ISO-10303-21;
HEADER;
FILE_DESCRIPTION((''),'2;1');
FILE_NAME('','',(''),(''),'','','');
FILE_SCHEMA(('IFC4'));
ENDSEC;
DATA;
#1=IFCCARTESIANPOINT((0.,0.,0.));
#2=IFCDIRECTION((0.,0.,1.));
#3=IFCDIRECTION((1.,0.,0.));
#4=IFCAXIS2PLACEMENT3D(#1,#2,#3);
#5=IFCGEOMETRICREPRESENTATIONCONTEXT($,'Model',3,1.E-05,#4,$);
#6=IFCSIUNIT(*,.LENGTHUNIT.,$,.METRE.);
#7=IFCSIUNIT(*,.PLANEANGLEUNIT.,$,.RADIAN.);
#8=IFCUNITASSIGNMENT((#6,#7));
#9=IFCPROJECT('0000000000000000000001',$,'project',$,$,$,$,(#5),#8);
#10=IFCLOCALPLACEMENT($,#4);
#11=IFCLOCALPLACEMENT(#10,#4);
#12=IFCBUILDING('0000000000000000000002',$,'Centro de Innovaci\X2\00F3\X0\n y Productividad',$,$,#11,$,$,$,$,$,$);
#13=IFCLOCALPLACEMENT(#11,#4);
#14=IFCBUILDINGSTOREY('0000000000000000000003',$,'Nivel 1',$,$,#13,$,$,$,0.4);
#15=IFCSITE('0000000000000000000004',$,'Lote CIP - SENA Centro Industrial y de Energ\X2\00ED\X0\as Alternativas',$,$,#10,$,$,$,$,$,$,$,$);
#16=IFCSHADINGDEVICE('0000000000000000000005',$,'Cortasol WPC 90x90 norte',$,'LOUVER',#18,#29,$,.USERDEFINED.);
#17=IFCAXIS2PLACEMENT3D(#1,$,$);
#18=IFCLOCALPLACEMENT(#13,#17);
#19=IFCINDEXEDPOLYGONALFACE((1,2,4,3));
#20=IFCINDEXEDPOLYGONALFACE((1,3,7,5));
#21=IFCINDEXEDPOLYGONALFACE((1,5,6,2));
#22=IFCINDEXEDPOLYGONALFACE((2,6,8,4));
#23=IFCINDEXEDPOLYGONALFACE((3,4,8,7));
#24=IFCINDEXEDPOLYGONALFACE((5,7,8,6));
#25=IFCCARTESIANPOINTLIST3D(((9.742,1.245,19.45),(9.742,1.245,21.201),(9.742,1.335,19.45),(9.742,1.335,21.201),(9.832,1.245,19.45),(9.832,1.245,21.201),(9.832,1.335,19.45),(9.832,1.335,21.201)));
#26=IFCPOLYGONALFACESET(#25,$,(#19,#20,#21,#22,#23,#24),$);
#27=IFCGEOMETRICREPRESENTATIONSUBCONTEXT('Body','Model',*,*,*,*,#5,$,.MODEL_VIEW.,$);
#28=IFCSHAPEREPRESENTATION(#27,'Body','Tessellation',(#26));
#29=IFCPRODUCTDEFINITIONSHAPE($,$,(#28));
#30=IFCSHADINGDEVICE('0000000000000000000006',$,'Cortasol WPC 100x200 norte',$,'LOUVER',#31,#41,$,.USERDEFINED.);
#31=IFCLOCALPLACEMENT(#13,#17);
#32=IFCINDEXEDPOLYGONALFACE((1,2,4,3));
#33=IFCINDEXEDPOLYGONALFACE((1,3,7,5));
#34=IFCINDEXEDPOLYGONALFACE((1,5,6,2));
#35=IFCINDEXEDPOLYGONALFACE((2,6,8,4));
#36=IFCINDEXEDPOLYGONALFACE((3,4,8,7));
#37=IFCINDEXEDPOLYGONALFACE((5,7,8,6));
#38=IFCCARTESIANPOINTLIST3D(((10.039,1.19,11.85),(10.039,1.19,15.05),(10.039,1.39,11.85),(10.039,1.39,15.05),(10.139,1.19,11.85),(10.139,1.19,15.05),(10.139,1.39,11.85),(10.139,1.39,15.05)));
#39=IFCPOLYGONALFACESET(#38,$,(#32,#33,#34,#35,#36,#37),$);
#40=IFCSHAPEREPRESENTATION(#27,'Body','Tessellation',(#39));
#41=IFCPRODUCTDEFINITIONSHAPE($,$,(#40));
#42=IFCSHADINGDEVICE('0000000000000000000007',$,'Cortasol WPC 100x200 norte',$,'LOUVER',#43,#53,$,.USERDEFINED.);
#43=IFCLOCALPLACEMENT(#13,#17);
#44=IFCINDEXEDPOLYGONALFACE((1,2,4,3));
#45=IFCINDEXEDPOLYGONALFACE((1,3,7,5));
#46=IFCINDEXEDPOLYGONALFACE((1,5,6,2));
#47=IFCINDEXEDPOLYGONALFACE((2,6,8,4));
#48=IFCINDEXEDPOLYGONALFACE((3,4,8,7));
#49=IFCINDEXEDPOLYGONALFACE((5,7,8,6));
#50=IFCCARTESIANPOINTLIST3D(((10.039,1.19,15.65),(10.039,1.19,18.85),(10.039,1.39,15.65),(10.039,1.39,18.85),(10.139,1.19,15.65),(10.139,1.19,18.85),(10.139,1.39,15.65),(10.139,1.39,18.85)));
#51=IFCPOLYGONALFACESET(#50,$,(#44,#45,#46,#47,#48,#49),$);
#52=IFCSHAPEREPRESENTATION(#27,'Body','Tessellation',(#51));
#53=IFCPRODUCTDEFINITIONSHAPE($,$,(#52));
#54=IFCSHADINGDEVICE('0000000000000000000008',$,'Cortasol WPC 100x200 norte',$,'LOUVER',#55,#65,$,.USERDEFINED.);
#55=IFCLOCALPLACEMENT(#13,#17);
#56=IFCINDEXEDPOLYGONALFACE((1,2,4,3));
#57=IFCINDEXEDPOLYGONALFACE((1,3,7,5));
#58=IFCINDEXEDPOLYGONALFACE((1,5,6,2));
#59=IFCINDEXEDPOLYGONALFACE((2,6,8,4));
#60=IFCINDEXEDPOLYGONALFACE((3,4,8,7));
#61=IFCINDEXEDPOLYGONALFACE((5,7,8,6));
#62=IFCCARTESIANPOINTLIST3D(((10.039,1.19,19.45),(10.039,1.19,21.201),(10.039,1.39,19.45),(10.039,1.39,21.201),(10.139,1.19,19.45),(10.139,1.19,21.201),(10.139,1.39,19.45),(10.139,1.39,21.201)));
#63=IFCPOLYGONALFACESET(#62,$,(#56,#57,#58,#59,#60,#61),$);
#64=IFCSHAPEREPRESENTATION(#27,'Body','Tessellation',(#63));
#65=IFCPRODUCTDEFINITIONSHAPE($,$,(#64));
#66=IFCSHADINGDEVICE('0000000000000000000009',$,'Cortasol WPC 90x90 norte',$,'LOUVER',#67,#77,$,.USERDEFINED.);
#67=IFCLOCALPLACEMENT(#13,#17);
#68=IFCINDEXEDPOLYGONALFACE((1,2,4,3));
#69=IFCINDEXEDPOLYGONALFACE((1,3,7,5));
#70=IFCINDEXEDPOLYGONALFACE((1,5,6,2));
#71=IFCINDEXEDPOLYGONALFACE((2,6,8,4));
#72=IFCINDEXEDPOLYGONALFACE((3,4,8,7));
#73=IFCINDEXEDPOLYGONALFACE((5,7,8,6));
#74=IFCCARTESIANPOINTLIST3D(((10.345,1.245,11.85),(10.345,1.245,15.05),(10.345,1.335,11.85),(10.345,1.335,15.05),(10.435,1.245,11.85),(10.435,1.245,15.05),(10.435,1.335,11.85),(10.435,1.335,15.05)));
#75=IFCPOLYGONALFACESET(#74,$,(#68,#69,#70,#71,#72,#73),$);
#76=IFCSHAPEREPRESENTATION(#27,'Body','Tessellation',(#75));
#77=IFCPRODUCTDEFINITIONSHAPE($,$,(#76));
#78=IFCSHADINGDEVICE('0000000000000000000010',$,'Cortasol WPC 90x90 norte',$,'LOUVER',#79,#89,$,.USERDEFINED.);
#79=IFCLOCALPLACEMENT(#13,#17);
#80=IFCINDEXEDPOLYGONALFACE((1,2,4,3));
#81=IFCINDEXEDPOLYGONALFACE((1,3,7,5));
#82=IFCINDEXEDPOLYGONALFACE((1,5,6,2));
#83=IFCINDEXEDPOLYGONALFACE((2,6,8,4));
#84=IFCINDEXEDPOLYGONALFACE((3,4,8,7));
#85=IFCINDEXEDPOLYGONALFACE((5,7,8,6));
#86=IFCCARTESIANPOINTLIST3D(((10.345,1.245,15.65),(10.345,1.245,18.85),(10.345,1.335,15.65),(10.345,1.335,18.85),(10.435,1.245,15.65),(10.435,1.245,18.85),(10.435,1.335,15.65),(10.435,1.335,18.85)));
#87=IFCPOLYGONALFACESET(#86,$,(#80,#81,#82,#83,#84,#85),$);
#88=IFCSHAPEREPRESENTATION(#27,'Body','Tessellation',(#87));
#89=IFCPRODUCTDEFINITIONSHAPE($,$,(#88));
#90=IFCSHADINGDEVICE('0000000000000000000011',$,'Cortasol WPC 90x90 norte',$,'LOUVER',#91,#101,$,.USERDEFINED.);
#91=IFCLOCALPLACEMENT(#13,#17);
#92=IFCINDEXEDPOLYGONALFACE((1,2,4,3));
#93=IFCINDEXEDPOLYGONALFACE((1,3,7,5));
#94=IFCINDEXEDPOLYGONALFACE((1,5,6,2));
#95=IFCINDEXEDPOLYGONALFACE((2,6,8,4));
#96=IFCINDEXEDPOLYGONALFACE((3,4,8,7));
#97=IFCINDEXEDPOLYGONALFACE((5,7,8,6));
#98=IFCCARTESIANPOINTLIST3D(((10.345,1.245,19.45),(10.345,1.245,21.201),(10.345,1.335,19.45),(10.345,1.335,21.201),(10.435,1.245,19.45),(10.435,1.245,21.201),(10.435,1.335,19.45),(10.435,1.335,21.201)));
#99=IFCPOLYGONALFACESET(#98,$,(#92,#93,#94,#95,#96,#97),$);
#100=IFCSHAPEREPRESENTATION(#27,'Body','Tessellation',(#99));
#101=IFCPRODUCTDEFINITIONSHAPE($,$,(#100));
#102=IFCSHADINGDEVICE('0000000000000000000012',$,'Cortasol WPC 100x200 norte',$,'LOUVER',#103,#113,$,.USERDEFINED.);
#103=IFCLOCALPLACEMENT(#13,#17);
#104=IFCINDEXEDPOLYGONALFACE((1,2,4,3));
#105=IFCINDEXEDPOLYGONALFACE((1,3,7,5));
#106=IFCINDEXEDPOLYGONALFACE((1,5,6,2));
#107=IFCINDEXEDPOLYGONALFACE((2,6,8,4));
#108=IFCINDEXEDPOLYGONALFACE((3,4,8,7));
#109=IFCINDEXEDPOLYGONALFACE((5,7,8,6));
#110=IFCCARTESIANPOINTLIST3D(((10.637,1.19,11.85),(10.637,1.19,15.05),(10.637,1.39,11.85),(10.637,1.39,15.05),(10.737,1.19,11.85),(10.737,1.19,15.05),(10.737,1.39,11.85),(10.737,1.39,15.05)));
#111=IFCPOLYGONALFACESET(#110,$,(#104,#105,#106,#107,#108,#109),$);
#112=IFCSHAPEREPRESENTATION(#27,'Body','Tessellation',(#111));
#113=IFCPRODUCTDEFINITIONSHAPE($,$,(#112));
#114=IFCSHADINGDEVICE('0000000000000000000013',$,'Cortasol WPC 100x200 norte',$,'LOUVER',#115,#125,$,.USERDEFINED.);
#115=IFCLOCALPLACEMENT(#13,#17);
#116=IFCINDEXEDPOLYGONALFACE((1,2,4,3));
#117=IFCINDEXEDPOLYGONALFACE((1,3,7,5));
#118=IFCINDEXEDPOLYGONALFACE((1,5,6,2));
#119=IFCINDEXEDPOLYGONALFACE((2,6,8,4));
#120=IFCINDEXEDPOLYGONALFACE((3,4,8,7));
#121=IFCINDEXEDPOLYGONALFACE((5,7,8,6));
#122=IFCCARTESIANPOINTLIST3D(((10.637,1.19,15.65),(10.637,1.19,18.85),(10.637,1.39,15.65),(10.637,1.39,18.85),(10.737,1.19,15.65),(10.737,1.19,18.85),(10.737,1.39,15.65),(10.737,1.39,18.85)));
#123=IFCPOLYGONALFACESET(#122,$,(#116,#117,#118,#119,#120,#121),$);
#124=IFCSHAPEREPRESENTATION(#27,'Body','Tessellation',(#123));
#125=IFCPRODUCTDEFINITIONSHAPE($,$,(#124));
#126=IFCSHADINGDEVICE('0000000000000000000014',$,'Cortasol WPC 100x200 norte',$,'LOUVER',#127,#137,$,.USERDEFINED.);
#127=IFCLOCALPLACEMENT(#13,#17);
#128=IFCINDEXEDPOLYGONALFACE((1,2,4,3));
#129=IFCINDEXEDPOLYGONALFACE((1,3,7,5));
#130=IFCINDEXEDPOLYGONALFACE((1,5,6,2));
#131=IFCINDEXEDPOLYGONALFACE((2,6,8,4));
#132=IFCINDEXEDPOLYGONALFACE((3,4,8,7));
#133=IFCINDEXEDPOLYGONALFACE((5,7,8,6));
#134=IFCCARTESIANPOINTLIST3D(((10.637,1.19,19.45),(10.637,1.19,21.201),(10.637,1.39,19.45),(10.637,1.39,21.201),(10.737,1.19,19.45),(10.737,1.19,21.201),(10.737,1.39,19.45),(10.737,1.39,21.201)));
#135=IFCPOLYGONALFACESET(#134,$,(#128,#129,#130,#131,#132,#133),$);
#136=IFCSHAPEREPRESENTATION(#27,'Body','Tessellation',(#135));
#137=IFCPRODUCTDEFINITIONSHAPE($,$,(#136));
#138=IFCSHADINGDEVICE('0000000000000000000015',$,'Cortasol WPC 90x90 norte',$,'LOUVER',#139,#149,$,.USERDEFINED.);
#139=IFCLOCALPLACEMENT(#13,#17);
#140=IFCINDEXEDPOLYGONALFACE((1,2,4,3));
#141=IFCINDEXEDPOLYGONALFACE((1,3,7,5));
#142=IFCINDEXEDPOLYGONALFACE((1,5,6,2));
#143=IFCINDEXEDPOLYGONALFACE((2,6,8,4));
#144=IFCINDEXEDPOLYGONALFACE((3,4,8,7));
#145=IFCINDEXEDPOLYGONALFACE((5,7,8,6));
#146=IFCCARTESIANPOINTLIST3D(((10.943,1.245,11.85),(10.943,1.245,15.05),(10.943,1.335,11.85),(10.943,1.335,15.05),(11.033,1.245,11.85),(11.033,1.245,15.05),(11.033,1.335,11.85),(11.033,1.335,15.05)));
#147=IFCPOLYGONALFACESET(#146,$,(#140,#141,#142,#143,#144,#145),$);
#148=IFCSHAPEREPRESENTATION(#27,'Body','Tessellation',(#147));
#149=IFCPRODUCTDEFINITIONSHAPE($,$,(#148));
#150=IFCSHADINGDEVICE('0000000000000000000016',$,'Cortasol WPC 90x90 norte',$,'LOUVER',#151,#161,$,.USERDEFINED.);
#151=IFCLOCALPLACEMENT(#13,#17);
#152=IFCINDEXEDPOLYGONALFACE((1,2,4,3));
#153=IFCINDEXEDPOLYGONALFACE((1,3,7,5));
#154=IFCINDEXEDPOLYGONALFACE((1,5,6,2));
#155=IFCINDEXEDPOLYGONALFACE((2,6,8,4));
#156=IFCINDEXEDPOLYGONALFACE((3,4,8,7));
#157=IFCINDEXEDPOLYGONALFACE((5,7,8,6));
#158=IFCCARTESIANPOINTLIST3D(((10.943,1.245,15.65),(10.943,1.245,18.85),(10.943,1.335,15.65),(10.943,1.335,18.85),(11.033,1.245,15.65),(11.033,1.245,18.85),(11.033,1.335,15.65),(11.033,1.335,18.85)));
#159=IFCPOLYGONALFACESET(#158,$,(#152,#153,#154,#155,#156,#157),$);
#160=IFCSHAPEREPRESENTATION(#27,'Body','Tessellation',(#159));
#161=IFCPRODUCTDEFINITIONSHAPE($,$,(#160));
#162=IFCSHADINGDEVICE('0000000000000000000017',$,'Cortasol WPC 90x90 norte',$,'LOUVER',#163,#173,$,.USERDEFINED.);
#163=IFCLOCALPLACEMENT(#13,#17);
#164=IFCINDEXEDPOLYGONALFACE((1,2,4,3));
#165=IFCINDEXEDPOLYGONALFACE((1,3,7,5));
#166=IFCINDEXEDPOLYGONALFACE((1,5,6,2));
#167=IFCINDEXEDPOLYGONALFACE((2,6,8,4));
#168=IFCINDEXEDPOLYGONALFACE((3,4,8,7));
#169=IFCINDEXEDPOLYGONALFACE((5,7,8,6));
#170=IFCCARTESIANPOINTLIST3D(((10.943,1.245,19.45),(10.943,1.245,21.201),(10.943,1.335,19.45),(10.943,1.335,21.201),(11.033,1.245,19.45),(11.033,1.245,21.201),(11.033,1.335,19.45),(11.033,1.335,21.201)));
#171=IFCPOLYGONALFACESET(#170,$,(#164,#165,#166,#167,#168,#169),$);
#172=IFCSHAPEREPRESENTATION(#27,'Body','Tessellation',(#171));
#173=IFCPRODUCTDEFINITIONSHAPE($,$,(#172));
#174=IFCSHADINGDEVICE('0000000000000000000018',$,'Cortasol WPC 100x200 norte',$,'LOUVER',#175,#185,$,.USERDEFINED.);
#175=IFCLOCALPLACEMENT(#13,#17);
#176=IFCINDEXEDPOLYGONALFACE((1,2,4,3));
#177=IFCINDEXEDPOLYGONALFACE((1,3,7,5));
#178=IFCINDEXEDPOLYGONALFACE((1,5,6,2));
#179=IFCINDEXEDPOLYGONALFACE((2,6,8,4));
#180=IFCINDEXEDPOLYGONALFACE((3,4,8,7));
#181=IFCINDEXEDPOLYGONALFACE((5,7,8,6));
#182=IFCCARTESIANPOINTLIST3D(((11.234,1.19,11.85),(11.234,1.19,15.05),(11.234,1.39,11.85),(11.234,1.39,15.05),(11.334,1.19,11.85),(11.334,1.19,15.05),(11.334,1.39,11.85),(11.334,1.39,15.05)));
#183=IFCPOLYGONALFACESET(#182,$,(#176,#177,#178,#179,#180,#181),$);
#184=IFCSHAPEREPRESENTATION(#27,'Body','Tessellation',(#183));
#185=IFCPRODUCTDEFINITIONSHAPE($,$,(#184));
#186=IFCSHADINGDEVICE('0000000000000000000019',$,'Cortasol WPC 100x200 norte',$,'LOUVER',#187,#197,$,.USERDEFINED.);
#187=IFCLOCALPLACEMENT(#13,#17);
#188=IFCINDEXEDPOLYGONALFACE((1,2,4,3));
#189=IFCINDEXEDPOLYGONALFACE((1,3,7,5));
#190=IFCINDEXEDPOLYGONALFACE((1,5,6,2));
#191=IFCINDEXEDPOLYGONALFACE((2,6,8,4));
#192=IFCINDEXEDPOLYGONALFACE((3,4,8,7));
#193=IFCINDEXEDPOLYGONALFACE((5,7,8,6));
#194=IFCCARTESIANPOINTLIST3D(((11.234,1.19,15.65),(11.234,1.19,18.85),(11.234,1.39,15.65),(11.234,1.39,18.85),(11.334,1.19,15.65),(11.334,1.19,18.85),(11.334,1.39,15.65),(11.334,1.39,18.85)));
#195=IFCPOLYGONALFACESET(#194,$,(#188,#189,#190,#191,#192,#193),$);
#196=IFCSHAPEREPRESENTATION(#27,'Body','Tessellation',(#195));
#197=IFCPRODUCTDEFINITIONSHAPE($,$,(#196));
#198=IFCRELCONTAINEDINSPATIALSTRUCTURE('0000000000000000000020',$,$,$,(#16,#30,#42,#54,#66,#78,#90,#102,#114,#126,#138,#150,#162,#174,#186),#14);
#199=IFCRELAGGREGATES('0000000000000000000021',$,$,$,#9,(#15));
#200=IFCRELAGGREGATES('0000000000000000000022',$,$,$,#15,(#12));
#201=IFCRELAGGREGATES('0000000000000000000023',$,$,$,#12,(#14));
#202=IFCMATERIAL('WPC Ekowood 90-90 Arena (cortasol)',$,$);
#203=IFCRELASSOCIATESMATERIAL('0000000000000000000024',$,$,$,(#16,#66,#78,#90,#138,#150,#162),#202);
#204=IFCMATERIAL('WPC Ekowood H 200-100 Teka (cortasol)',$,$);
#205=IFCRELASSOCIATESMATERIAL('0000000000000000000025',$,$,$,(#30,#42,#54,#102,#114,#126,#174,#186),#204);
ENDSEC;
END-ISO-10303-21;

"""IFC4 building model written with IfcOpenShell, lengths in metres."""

from ifc_helpers import new_model, si_unit, frame, origin_with_axes, place, context, subcontext, project, spatial, polyline, outline, extrude, material, element, save


model = new_model("IFC4")

# Units and contexts
model_context = context("Model", 3, precision=1e-05, world=origin_with_axes())
body_context = subcontext(model_context, "Body", "Model", "MODEL_VIEW")
ifc_project = project(units=[si_unit("LENGTHUNIT", "METRE"), si_unit("PLANEANGLEUNIT", "RADIAN")], contexts=[model_context])

# Site, building, storey
site_placement = place(None, origin_with_axes())
site = spatial("IfcSite", under=ifc_project, at=site_placement, Name="Lote CIP - SENA Centro Industrial y de Energías Alternativas")
building_placement = place(site_placement, origin_with_axes())
building = spatial("IfcBuilding", under=site, at=building_placement, Name="Centro de Innovación y Productividad")
storey_placement = place(building_placement, origin_with_axes())
storey = spatial("IfcBuildingStorey", under=building, at=storey_placement, Name="Nivel 1", Elevation=0.4)

# Shading devices
ifc_material_1 = material(Name="WPC Ekowood 90-90 Arena (cortasol)")
shading_device_1_placement = place(storey_placement, origin_with_axes())
element("IfcShadingDevice", 1, at=shading_device_1_placement, inside=storey, material=ifc_material_1, Name="Cortasol WPC 90x90 norte", ObjectType="LOUVER", PredefinedType="USERDEFINED", context=body_context, shape_type="SweptSolid", body=[
    extrude(outline(polyline([(9.742, 1.245), (9.742, 1.335), (9.832, 1.335), (9.832, 1.245), (9.742, 1.245)])), frame((0.0, 0.0, 19.45)), (0.0, 0.0, 1.0), 1.751),
])
ifc_material_2 = material(Name="WPC Ekowood H 200-100 Teka (cortasol)")
shading_device_2_placement = place(storey_placement, origin_with_axes())
element("IfcShadingDevice", 2, at=shading_device_2_placement, inside=storey, material=ifc_material_2, Name="Cortasol WPC 100x200 norte", ObjectType="LOUVER", PredefinedType="USERDEFINED", context=body_context, shape_type="SweptSolid", body=[
    extrude(outline(polyline([(10.039, 1.19), (10.039, 1.39), (10.139, 1.39), (10.139, 1.19), (10.039, 1.19)])), frame((0.0, 0.0, 11.85)), (0.0, 0.0, 1.0), 3.2),
])
shading_device_3_placement = place(storey_placement, origin_with_axes())
element("IfcShadingDevice", 3, at=shading_device_3_placement, inside=storey, material=ifc_material_2, Name="Cortasol WPC 100x200 norte", ObjectType="LOUVER", PredefinedType="USERDEFINED", context=body_context, shape_type="SweptSolid", body=[
    extrude(outline(polyline([(10.039, 1.19), (10.039, 1.39), (10.139, 1.39), (10.139, 1.19), (10.039, 1.19)])), frame((0.0, 0.0, 15.65)), (0.0, 0.0, 1.0), 3.2),
])
shading_device_4_placement = place(storey_placement, origin_with_axes())
element("IfcShadingDevice", 4, at=shading_device_4_placement, inside=storey, material=ifc_material_2, Name="Cortasol WPC 100x200 norte", ObjectType="LOUVER", PredefinedType="USERDEFINED", context=body_context, shape_type="SweptSolid", body=[
    extrude(outline(polyline([(10.039, 1.19), (10.039, 1.39), (10.139, 1.39), (10.139, 1.19), (10.039, 1.19)])), frame((0.0, 0.0, 19.45)), (0.0, 0.0, 1.0), 1.751),
])
shading_device_5_placement = place(storey_placement, origin_with_axes())
element("IfcShadingDevice", 5, at=shading_device_5_placement, inside=storey, material=ifc_material_1, Name="Cortasol WPC 90x90 norte", ObjectType="LOUVER", PredefinedType="USERDEFINED", context=body_context, shape_type="SweptSolid", body=[
    extrude(outline(polyline([(10.345, 1.245), (10.345, 1.335), (10.435, 1.335), (10.435, 1.245), (10.345, 1.245)])), frame((0.0, 0.0, 11.85)), (0.0, 0.0, 1.0), 3.2),
])
shading_device_6_placement = place(storey_placement, origin_with_axes())
element("IfcShadingDevice", 6, at=shading_device_6_placement, inside=storey, material=ifc_material_1, Name="Cortasol WPC 90x90 norte", ObjectType="LOUVER", PredefinedType="USERDEFINED", context=body_context, shape_type="SweptSolid", body=[
    extrude(outline(polyline([(10.345, 1.245), (10.345, 1.335), (10.435, 1.335), (10.435, 1.245), (10.345, 1.245)])), frame((0.0, 0.0, 15.65)), (0.0, 0.0, 1.0), 3.2),
])
shading_device_7_placement = place(storey_placement, origin_with_axes())
element("IfcShadingDevice", 7, at=shading_device_7_placement, inside=storey, material=ifc_material_1, Name="Cortasol WPC 90x90 norte", ObjectType="LOUVER", PredefinedType="USERDEFINED", context=body_context, shape_type="SweptSolid", body=[
    extrude(outline(polyline([(10.345, 1.245), (10.345, 1.335), (10.435, 1.335), (10.435, 1.245), (10.345, 1.245)])), frame((0.0, 0.0, 19.45)), (0.0, 0.0, 1.0), 1.751),
])
shading_device_8_placement = place(storey_placement, origin_with_axes())
element("IfcShadingDevice", 8, at=shading_device_8_placement, inside=storey, material=ifc_material_2, Name="Cortasol WPC 100x200 norte", ObjectType="LOUVER", PredefinedType="USERDEFINED", context=body_context, shape_type="SweptSolid", body=[
    extrude(outline(polyline([(10.637, 1.19), (10.637, 1.39), (10.737, 1.39), (10.737, 1.19), (10.637, 1.19)])), frame((0.0, 0.0, 11.85)), (0.0, 0.0, 1.0), 3.2),
])
shading_device_9_placement = place(storey_placement, origin_with_axes())
element("IfcShadingDevice", 9, at=shading_device_9_placement, inside=storey, material=ifc_material_2, Name="Cortasol WPC 100x200 norte", ObjectType="LOUVER", PredefinedType="USERDEFINED", context=body_context, shape_type="SweptSolid", body=[
    extrude(outline(polyline([(10.637, 1.19), (10.637, 1.39), (10.737, 1.39), (10.737, 1.19), (10.637, 1.19)])), frame((0.0, 0.0, 15.65)), (0.0, 0.0, 1.0), 3.2),
])
shading_device_10_placement = place(storey_placement, origin_with_axes())
element("IfcShadingDevice", 10, at=shading_device_10_placement, inside=storey, material=ifc_material_2, Name="Cortasol WPC 100x200 norte", ObjectType="LOUVER", PredefinedType="USERDEFINED", context=body_context, shape_type="SweptSolid", body=[
    extrude(outline(polyline([(10.637, 1.19), (10.637, 1.39), (10.737, 1.39), (10.737, 1.19), (10.637, 1.19)])), frame((0.0, 0.0, 19.45)), (0.0, 0.0, 1.0), 1.751),
])
shading_device_11_placement = place(storey_placement, origin_with_axes())
element("IfcShadingDevice", 11, at=shading_device_11_placement, inside=storey, material=ifc_material_1, Name="Cortasol WPC 90x90 norte", ObjectType="LOUVER", PredefinedType="USERDEFINED", context=body_context, shape_type="SweptSolid", body=[
    extrude(outline(polyline([(10.943, 1.245), (10.943, 1.335), (11.033, 1.335), (11.033, 1.245), (10.943, 1.245)])), frame((0.0, 0.0, 11.85)), (0.0, 0.0, 1.0), 3.2),
])
shading_device_12_placement = place(storey_placement, origin_with_axes())
element("IfcShadingDevice", 12, at=shading_device_12_placement, inside=storey, material=ifc_material_1, Name="Cortasol WPC 90x90 norte", ObjectType="LOUVER", PredefinedType="USERDEFINED", context=body_context, shape_type="SweptSolid", body=[
    extrude(outline(polyline([(10.943, 1.245), (10.943, 1.335), (11.033, 1.335), (11.033, 1.245), (10.943, 1.245)])), frame((0.0, 0.0, 15.65)), (0.0, 0.0, 1.0), 3.2),
])
shading_device_13_placement = place(storey_placement, origin_with_axes())
element("IfcShadingDevice", 13, at=shading_device_13_placement, inside=storey, material=ifc_material_1, Name="Cortasol WPC 90x90 norte", ObjectType="LOUVER", PredefinedType="USERDEFINED", context=body_context, shape_type="SweptSolid", body=[
    extrude(outline(polyline([(10.943, 1.245), (10.943, 1.335), (11.033, 1.335), (11.033, 1.245), (10.943, 1.245)])), frame((0.0, 0.0, 19.45)), (0.0, 0.0, 1.0), 1.751),
])
shading_device_14_placement = place(storey_placement, origin_with_axes())
element("IfcShadingDevice", 14, at=shading_device_14_placement, inside=storey, material=ifc_material_2, Name="Cortasol WPC 100x200 norte", ObjectType="LOUVER", PredefinedType="USERDEFINED", context=body_context, shape_type="SweptSolid", body=[
    extrude(outline(polyline([(11.234, 1.19), (11.234, 1.39), (11.334, 1.39), (11.334, 1.19), (11.234, 1.19)])), frame((0.0, 0.0, 11.85)), (0.0, 0.0, 1.0), 3.2),
])
shading_device_15_placement = place(storey_placement, origin_with_axes())
element("IfcShadingDevice", 15, at=shading_device_15_placement, inside=storey, material=ifc_material_2, Name="Cortasol WPC 100x200 norte", ObjectType="LOUVER", PredefinedType="USERDEFINED", context=body_context, shape_type="SweptSolid", body=[
    extrude(outline(polyline([(11.234, 1.19), (11.234, 1.39), (11.334, 1.39), (11.334, 1.19), (11.234, 1.19)])), frame((0.0, 0.0, 15.65)), (0.0, 0.0, 1.0), 3.2),
])

save(model, "model.ifc")
